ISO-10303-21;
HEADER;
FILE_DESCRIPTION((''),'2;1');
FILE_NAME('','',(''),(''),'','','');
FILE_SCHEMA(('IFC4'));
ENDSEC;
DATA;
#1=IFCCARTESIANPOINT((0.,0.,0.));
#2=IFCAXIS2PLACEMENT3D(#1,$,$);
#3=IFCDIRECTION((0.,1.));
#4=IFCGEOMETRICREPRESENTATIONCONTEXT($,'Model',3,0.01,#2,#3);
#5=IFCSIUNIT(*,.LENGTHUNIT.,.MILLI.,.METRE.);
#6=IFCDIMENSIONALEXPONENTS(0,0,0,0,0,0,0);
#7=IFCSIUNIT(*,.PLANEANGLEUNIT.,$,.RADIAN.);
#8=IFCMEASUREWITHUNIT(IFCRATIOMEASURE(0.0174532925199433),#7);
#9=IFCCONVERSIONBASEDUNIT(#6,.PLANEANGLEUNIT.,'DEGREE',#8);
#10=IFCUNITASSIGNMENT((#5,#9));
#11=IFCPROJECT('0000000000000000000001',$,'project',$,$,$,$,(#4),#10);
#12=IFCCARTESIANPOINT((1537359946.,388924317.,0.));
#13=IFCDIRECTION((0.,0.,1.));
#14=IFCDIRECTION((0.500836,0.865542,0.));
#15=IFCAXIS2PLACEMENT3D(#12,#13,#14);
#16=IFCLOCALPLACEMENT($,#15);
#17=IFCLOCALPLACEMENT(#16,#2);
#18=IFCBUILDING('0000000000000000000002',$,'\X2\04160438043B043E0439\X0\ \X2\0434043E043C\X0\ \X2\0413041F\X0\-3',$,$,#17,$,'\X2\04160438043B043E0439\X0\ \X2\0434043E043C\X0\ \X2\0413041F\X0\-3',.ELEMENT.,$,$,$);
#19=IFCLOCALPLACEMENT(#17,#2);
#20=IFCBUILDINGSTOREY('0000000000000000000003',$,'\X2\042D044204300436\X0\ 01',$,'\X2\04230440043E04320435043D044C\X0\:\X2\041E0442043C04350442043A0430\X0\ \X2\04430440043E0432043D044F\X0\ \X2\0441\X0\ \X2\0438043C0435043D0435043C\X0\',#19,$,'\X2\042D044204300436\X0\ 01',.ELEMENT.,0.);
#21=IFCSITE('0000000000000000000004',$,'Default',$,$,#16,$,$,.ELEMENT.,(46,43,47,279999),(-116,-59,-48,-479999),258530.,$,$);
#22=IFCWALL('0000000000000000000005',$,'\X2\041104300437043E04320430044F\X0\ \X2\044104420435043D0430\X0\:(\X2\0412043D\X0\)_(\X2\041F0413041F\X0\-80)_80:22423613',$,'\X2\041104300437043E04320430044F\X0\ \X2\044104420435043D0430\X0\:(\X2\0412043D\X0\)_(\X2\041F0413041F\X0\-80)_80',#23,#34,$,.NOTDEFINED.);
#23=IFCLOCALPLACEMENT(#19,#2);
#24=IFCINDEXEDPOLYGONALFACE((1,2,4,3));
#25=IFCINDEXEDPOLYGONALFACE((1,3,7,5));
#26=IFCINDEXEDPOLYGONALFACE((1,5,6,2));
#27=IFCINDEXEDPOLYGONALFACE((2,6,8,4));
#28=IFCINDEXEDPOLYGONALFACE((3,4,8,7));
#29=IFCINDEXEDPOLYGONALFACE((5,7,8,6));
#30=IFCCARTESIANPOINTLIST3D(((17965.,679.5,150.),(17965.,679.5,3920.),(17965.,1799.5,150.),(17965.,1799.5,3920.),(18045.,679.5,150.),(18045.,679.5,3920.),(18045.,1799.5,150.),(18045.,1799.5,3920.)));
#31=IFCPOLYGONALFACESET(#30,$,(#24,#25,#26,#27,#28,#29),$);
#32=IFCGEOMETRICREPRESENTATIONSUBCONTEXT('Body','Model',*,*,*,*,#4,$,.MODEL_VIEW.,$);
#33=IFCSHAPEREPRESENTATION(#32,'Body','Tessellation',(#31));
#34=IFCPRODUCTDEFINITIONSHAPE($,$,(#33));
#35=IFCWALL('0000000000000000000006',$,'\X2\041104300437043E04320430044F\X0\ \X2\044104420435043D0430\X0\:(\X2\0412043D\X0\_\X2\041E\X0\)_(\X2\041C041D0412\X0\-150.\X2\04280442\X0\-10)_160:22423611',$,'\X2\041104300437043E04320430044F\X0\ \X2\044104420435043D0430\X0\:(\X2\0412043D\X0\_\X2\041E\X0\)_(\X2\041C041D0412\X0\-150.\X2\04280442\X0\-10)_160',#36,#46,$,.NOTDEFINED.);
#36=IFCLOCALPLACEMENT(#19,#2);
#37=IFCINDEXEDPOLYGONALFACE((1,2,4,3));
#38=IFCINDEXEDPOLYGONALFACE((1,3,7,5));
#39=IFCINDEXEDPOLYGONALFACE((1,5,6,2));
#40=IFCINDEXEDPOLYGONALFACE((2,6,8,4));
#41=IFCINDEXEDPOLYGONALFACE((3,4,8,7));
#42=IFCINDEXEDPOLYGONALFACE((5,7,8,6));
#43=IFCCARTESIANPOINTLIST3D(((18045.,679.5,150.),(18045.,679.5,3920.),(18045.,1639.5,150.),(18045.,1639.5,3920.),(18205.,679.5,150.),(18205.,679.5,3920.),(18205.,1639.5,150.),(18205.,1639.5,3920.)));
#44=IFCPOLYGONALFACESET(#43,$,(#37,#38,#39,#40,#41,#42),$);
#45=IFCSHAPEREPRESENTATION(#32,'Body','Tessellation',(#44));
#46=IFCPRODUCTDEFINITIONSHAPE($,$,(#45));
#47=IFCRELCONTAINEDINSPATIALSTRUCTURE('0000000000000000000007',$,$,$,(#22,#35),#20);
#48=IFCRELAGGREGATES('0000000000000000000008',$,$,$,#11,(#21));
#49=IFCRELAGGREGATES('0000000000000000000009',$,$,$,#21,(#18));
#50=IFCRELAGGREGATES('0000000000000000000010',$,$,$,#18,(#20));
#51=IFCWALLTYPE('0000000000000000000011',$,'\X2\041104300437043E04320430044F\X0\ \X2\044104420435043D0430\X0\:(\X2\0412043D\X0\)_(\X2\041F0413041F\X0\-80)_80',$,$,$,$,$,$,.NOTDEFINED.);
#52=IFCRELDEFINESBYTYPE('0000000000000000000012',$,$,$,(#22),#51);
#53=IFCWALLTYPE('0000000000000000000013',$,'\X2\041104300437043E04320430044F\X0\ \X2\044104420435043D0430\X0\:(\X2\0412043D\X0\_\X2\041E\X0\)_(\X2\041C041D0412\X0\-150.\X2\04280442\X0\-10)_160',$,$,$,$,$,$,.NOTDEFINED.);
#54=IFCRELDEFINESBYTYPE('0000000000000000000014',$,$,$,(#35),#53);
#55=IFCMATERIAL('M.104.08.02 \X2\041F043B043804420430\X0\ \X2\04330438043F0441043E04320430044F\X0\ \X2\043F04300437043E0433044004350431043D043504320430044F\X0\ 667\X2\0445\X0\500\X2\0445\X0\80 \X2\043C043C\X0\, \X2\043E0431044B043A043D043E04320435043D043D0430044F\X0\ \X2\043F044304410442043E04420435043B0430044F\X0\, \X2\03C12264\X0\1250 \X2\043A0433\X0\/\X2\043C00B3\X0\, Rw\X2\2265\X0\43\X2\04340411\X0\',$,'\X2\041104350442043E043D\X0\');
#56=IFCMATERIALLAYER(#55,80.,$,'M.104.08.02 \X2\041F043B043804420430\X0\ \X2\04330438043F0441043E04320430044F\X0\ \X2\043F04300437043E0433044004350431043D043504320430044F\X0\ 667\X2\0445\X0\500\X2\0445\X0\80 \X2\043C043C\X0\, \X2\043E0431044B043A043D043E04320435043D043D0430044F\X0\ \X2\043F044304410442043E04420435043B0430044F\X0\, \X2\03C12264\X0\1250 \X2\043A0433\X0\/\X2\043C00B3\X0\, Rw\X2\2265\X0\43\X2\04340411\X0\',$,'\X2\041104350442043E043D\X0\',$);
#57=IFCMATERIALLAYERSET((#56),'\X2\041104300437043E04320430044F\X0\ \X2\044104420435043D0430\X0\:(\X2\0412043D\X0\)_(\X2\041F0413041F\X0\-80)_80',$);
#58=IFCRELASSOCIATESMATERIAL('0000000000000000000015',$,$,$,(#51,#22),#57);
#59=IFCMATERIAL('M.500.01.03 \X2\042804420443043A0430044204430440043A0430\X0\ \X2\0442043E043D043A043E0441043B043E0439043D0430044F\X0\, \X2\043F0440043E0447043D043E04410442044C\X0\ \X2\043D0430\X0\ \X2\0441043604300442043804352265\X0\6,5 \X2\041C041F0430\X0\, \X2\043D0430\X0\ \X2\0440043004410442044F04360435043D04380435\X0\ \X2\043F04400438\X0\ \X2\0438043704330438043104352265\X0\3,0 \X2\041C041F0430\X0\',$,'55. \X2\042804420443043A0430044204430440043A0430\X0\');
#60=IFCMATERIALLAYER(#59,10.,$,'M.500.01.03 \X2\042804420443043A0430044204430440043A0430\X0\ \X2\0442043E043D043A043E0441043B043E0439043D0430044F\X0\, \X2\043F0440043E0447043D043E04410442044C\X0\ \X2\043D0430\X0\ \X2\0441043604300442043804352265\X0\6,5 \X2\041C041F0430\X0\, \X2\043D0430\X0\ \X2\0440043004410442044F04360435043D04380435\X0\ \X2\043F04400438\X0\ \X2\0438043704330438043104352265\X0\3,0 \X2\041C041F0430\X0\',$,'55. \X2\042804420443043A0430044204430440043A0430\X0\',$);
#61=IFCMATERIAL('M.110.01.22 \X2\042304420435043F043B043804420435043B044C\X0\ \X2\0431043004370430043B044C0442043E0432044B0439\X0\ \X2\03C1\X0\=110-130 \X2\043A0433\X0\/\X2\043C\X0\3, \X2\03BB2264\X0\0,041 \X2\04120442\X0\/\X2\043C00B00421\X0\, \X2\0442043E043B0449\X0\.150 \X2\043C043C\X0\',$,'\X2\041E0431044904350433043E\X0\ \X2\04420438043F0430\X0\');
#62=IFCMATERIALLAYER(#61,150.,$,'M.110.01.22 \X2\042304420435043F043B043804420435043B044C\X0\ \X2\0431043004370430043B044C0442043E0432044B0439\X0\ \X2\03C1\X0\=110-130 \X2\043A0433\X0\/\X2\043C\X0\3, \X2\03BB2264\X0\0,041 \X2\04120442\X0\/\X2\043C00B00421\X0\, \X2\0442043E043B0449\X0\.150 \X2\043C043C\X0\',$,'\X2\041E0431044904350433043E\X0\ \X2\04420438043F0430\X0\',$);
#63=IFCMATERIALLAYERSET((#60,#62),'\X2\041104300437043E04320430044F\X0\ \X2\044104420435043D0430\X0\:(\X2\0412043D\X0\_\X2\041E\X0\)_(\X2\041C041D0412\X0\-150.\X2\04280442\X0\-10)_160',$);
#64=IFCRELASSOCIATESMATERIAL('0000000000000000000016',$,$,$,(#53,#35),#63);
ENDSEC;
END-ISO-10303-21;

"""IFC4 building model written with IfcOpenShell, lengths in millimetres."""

from ifc_helpers import new_model, entity, si_unit, converted_unit, direction, frame, frame_2d, origin, place, context, subcontext, project, spatial, rectangle, extrude, material, layer, layer_set, layer_usage, type_object, element, save


model = new_model("IFC4")

# Units and contexts
model_context = context("Model", 3, precision=0.01, world=origin(), true_north=direction((0.0, 1.0)))
body_context = subcontext(model_context, "Body", "Model", "MODEL_VIEW")
ifc_project = project(units=[si_unit("LENGTHUNIT", "METRE", prefix="MILLI"), converted_unit("PLANEANGLEUNIT", "DEGREE", entity("IfcRatioMeasure", 0.0174532925199433), si_unit("PLANEANGLEUNIT", "RADIAN"), dimensions=[0, 0, 0, 0, 0, 0, 0])], contexts=[model_context])

# Site, building, storey
site_placement = place(None, frame((1537359946.0, 388924317.0, 0.0), z_axis=(0.0, 0.0, 1.0), x_axis=(0.500836, 0.865542, 0.0)))
site = spatial("IfcSite", under=ifc_project, at=site_placement, Name="Default", CompositionType="ELEMENT", RefLatitude=(46, 43, 47, 279999), RefLongitude=(-116, -59, -48, -479999), RefElevation=258530.0)
building_placement = place(site_placement, origin())
building = spatial("IfcBuilding", under=site, at=building_placement, Name="Жилой дом ГП-3", LongName="Жилой дом ГП-3", CompositionType="ELEMENT")
storey_placement = place(building_placement, origin())
storey = spatial("IfcBuildingStorey", under=building, at=storey_placement, Name="Этаж 01", ObjectType="Уровень:Отметка уровня с именем", LongName="Этаж 01", CompositionType="ELEMENT", Elevation=0.0)

# Walls
ifc_material_1 = material(Name="M.104.08.02 Плита гипсовая пазогребневая 667х500х80 мм, обыкновенная пустотелая, ρ≤1250 кг/м³, Rw≥43дБ", Category="Бетон")
ifc_layer_1 = layer(ifc_material_1, 80.0, Name="M.104.08.02 Плита гипсовая пазогребневая 667х500х80 мм, обыкновенная пустотелая, ρ≤1250 кг/м³, Rw≥43дБ", Category="Бетон")
ifc_layer_set_1 = layer_set([ifc_layer_1], Name="Базовая стена:(Вн)_(ПГП-80)_80")
ifc_layer_usage_1 = layer_usage(ifc_layer_set_1, "AXIS2", "NEGATIVE", 40.0)
wall_type_1 = type_object("IfcWallType", Name="Базовая стена:(Вн)_(ПГП-80)_80", PredefinedType="NOTDEFINED", material=ifc_layer_set_1)
wall_1_placement = place(storey_placement, frame((18005.0, 1799.5, 150.0), z_axis=(0.0, 0.0, 1.0), x_axis=(0.0, -1.0, 0.0)))
element("IfcWall", 1, at=wall_1_placement, inside=storey, type_object=wall_type_1, material=ifc_layer_usage_1, Name="Базовая стена:(Вн)_(ПГП-80)_80:22423613", ObjectType="Базовая стена:(Вн)_(ПГП-80)_80", PredefinedType="NOTDEFINED", context=body_context, shape_type="SweptSolid", body=[
    extrude(rectangle(XDim=1120.0, YDim=80.0, at=frame_2d((560.0, 0.0), x_axis=(-1.0, 0.0))), origin(), (0.0, 0.0, 1.0), 3770.0),
])
ifc_material_2 = material(Name="M.500.01.03 Штукатурка тонкослойная, прочность на сжатие≥6,5 МПа, на растяжение при изгибе≥3,0 МПа", Category="55. Штукатурка")
ifc_layer_2 = layer(ifc_material_2, 10.0, Name="M.500.01.03 Штукатурка тонкослойная, прочность на сжатие≥6,5 МПа, на растяжение при изгибе≥3,0 МПа", Category="55. Штукатурка")
ifc_material_3 = material(Name="M.110.01.22 Утеплитель базальтовый ρ=110-130 кг/м3, λ≤0,041 Вт/м°С, толщ.150 мм", Category="Общего типа")
ifc_layer_3 = layer(ifc_material_3, 150.0, Name="M.110.01.22 Утеплитель базальтовый ρ=110-130 кг/м3, λ≤0,041 Вт/м°С, толщ.150 мм", Category="Общего типа")
ifc_layer_set_2 = layer_set([ifc_layer_2, ifc_layer_3], Name="Базовая стена:(Вн_О)_(МНВ-150.Шт-10)_160")
ifc_layer_usage_2 = layer_usage(ifc_layer_set_2, "AXIS2", "NEGATIVE", 80.0)
wall_type_2 = type_object("IfcWallType", Name="Базовая стена:(Вн_О)_(МНВ-150.Шт-10)_160", PredefinedType="NOTDEFINED", material=ifc_layer_set_2)
wall_2_placement = place(storey_placement, frame((18125.0, 1639.5, 150.0), z_axis=(0.0, 0.0, 1.0), x_axis=(0.0, -1.0, 0.0)))
element("IfcWall", 2, at=wall_2_placement, inside=storey, type_object=wall_type_2, material=ifc_layer_usage_2, Name="Базовая стена:(Вн_О)_(МНВ-150.Шт-10)_160:22423611", ObjectType="Базовая стена:(Вн_О)_(МНВ-150.Шт-10)_160", PredefinedType="NOTDEFINED", context=body_context, shape_type="SweptSolid", body=[
    extrude(rectangle(XDim=960.0, YDim=160.0, at=frame_2d((480.0, 0.0), x_axis=(-1.0, 0.0))), origin(), (0.0, 0.0, 1.0), 3770.0),
])

save(model, "model.ifc")
